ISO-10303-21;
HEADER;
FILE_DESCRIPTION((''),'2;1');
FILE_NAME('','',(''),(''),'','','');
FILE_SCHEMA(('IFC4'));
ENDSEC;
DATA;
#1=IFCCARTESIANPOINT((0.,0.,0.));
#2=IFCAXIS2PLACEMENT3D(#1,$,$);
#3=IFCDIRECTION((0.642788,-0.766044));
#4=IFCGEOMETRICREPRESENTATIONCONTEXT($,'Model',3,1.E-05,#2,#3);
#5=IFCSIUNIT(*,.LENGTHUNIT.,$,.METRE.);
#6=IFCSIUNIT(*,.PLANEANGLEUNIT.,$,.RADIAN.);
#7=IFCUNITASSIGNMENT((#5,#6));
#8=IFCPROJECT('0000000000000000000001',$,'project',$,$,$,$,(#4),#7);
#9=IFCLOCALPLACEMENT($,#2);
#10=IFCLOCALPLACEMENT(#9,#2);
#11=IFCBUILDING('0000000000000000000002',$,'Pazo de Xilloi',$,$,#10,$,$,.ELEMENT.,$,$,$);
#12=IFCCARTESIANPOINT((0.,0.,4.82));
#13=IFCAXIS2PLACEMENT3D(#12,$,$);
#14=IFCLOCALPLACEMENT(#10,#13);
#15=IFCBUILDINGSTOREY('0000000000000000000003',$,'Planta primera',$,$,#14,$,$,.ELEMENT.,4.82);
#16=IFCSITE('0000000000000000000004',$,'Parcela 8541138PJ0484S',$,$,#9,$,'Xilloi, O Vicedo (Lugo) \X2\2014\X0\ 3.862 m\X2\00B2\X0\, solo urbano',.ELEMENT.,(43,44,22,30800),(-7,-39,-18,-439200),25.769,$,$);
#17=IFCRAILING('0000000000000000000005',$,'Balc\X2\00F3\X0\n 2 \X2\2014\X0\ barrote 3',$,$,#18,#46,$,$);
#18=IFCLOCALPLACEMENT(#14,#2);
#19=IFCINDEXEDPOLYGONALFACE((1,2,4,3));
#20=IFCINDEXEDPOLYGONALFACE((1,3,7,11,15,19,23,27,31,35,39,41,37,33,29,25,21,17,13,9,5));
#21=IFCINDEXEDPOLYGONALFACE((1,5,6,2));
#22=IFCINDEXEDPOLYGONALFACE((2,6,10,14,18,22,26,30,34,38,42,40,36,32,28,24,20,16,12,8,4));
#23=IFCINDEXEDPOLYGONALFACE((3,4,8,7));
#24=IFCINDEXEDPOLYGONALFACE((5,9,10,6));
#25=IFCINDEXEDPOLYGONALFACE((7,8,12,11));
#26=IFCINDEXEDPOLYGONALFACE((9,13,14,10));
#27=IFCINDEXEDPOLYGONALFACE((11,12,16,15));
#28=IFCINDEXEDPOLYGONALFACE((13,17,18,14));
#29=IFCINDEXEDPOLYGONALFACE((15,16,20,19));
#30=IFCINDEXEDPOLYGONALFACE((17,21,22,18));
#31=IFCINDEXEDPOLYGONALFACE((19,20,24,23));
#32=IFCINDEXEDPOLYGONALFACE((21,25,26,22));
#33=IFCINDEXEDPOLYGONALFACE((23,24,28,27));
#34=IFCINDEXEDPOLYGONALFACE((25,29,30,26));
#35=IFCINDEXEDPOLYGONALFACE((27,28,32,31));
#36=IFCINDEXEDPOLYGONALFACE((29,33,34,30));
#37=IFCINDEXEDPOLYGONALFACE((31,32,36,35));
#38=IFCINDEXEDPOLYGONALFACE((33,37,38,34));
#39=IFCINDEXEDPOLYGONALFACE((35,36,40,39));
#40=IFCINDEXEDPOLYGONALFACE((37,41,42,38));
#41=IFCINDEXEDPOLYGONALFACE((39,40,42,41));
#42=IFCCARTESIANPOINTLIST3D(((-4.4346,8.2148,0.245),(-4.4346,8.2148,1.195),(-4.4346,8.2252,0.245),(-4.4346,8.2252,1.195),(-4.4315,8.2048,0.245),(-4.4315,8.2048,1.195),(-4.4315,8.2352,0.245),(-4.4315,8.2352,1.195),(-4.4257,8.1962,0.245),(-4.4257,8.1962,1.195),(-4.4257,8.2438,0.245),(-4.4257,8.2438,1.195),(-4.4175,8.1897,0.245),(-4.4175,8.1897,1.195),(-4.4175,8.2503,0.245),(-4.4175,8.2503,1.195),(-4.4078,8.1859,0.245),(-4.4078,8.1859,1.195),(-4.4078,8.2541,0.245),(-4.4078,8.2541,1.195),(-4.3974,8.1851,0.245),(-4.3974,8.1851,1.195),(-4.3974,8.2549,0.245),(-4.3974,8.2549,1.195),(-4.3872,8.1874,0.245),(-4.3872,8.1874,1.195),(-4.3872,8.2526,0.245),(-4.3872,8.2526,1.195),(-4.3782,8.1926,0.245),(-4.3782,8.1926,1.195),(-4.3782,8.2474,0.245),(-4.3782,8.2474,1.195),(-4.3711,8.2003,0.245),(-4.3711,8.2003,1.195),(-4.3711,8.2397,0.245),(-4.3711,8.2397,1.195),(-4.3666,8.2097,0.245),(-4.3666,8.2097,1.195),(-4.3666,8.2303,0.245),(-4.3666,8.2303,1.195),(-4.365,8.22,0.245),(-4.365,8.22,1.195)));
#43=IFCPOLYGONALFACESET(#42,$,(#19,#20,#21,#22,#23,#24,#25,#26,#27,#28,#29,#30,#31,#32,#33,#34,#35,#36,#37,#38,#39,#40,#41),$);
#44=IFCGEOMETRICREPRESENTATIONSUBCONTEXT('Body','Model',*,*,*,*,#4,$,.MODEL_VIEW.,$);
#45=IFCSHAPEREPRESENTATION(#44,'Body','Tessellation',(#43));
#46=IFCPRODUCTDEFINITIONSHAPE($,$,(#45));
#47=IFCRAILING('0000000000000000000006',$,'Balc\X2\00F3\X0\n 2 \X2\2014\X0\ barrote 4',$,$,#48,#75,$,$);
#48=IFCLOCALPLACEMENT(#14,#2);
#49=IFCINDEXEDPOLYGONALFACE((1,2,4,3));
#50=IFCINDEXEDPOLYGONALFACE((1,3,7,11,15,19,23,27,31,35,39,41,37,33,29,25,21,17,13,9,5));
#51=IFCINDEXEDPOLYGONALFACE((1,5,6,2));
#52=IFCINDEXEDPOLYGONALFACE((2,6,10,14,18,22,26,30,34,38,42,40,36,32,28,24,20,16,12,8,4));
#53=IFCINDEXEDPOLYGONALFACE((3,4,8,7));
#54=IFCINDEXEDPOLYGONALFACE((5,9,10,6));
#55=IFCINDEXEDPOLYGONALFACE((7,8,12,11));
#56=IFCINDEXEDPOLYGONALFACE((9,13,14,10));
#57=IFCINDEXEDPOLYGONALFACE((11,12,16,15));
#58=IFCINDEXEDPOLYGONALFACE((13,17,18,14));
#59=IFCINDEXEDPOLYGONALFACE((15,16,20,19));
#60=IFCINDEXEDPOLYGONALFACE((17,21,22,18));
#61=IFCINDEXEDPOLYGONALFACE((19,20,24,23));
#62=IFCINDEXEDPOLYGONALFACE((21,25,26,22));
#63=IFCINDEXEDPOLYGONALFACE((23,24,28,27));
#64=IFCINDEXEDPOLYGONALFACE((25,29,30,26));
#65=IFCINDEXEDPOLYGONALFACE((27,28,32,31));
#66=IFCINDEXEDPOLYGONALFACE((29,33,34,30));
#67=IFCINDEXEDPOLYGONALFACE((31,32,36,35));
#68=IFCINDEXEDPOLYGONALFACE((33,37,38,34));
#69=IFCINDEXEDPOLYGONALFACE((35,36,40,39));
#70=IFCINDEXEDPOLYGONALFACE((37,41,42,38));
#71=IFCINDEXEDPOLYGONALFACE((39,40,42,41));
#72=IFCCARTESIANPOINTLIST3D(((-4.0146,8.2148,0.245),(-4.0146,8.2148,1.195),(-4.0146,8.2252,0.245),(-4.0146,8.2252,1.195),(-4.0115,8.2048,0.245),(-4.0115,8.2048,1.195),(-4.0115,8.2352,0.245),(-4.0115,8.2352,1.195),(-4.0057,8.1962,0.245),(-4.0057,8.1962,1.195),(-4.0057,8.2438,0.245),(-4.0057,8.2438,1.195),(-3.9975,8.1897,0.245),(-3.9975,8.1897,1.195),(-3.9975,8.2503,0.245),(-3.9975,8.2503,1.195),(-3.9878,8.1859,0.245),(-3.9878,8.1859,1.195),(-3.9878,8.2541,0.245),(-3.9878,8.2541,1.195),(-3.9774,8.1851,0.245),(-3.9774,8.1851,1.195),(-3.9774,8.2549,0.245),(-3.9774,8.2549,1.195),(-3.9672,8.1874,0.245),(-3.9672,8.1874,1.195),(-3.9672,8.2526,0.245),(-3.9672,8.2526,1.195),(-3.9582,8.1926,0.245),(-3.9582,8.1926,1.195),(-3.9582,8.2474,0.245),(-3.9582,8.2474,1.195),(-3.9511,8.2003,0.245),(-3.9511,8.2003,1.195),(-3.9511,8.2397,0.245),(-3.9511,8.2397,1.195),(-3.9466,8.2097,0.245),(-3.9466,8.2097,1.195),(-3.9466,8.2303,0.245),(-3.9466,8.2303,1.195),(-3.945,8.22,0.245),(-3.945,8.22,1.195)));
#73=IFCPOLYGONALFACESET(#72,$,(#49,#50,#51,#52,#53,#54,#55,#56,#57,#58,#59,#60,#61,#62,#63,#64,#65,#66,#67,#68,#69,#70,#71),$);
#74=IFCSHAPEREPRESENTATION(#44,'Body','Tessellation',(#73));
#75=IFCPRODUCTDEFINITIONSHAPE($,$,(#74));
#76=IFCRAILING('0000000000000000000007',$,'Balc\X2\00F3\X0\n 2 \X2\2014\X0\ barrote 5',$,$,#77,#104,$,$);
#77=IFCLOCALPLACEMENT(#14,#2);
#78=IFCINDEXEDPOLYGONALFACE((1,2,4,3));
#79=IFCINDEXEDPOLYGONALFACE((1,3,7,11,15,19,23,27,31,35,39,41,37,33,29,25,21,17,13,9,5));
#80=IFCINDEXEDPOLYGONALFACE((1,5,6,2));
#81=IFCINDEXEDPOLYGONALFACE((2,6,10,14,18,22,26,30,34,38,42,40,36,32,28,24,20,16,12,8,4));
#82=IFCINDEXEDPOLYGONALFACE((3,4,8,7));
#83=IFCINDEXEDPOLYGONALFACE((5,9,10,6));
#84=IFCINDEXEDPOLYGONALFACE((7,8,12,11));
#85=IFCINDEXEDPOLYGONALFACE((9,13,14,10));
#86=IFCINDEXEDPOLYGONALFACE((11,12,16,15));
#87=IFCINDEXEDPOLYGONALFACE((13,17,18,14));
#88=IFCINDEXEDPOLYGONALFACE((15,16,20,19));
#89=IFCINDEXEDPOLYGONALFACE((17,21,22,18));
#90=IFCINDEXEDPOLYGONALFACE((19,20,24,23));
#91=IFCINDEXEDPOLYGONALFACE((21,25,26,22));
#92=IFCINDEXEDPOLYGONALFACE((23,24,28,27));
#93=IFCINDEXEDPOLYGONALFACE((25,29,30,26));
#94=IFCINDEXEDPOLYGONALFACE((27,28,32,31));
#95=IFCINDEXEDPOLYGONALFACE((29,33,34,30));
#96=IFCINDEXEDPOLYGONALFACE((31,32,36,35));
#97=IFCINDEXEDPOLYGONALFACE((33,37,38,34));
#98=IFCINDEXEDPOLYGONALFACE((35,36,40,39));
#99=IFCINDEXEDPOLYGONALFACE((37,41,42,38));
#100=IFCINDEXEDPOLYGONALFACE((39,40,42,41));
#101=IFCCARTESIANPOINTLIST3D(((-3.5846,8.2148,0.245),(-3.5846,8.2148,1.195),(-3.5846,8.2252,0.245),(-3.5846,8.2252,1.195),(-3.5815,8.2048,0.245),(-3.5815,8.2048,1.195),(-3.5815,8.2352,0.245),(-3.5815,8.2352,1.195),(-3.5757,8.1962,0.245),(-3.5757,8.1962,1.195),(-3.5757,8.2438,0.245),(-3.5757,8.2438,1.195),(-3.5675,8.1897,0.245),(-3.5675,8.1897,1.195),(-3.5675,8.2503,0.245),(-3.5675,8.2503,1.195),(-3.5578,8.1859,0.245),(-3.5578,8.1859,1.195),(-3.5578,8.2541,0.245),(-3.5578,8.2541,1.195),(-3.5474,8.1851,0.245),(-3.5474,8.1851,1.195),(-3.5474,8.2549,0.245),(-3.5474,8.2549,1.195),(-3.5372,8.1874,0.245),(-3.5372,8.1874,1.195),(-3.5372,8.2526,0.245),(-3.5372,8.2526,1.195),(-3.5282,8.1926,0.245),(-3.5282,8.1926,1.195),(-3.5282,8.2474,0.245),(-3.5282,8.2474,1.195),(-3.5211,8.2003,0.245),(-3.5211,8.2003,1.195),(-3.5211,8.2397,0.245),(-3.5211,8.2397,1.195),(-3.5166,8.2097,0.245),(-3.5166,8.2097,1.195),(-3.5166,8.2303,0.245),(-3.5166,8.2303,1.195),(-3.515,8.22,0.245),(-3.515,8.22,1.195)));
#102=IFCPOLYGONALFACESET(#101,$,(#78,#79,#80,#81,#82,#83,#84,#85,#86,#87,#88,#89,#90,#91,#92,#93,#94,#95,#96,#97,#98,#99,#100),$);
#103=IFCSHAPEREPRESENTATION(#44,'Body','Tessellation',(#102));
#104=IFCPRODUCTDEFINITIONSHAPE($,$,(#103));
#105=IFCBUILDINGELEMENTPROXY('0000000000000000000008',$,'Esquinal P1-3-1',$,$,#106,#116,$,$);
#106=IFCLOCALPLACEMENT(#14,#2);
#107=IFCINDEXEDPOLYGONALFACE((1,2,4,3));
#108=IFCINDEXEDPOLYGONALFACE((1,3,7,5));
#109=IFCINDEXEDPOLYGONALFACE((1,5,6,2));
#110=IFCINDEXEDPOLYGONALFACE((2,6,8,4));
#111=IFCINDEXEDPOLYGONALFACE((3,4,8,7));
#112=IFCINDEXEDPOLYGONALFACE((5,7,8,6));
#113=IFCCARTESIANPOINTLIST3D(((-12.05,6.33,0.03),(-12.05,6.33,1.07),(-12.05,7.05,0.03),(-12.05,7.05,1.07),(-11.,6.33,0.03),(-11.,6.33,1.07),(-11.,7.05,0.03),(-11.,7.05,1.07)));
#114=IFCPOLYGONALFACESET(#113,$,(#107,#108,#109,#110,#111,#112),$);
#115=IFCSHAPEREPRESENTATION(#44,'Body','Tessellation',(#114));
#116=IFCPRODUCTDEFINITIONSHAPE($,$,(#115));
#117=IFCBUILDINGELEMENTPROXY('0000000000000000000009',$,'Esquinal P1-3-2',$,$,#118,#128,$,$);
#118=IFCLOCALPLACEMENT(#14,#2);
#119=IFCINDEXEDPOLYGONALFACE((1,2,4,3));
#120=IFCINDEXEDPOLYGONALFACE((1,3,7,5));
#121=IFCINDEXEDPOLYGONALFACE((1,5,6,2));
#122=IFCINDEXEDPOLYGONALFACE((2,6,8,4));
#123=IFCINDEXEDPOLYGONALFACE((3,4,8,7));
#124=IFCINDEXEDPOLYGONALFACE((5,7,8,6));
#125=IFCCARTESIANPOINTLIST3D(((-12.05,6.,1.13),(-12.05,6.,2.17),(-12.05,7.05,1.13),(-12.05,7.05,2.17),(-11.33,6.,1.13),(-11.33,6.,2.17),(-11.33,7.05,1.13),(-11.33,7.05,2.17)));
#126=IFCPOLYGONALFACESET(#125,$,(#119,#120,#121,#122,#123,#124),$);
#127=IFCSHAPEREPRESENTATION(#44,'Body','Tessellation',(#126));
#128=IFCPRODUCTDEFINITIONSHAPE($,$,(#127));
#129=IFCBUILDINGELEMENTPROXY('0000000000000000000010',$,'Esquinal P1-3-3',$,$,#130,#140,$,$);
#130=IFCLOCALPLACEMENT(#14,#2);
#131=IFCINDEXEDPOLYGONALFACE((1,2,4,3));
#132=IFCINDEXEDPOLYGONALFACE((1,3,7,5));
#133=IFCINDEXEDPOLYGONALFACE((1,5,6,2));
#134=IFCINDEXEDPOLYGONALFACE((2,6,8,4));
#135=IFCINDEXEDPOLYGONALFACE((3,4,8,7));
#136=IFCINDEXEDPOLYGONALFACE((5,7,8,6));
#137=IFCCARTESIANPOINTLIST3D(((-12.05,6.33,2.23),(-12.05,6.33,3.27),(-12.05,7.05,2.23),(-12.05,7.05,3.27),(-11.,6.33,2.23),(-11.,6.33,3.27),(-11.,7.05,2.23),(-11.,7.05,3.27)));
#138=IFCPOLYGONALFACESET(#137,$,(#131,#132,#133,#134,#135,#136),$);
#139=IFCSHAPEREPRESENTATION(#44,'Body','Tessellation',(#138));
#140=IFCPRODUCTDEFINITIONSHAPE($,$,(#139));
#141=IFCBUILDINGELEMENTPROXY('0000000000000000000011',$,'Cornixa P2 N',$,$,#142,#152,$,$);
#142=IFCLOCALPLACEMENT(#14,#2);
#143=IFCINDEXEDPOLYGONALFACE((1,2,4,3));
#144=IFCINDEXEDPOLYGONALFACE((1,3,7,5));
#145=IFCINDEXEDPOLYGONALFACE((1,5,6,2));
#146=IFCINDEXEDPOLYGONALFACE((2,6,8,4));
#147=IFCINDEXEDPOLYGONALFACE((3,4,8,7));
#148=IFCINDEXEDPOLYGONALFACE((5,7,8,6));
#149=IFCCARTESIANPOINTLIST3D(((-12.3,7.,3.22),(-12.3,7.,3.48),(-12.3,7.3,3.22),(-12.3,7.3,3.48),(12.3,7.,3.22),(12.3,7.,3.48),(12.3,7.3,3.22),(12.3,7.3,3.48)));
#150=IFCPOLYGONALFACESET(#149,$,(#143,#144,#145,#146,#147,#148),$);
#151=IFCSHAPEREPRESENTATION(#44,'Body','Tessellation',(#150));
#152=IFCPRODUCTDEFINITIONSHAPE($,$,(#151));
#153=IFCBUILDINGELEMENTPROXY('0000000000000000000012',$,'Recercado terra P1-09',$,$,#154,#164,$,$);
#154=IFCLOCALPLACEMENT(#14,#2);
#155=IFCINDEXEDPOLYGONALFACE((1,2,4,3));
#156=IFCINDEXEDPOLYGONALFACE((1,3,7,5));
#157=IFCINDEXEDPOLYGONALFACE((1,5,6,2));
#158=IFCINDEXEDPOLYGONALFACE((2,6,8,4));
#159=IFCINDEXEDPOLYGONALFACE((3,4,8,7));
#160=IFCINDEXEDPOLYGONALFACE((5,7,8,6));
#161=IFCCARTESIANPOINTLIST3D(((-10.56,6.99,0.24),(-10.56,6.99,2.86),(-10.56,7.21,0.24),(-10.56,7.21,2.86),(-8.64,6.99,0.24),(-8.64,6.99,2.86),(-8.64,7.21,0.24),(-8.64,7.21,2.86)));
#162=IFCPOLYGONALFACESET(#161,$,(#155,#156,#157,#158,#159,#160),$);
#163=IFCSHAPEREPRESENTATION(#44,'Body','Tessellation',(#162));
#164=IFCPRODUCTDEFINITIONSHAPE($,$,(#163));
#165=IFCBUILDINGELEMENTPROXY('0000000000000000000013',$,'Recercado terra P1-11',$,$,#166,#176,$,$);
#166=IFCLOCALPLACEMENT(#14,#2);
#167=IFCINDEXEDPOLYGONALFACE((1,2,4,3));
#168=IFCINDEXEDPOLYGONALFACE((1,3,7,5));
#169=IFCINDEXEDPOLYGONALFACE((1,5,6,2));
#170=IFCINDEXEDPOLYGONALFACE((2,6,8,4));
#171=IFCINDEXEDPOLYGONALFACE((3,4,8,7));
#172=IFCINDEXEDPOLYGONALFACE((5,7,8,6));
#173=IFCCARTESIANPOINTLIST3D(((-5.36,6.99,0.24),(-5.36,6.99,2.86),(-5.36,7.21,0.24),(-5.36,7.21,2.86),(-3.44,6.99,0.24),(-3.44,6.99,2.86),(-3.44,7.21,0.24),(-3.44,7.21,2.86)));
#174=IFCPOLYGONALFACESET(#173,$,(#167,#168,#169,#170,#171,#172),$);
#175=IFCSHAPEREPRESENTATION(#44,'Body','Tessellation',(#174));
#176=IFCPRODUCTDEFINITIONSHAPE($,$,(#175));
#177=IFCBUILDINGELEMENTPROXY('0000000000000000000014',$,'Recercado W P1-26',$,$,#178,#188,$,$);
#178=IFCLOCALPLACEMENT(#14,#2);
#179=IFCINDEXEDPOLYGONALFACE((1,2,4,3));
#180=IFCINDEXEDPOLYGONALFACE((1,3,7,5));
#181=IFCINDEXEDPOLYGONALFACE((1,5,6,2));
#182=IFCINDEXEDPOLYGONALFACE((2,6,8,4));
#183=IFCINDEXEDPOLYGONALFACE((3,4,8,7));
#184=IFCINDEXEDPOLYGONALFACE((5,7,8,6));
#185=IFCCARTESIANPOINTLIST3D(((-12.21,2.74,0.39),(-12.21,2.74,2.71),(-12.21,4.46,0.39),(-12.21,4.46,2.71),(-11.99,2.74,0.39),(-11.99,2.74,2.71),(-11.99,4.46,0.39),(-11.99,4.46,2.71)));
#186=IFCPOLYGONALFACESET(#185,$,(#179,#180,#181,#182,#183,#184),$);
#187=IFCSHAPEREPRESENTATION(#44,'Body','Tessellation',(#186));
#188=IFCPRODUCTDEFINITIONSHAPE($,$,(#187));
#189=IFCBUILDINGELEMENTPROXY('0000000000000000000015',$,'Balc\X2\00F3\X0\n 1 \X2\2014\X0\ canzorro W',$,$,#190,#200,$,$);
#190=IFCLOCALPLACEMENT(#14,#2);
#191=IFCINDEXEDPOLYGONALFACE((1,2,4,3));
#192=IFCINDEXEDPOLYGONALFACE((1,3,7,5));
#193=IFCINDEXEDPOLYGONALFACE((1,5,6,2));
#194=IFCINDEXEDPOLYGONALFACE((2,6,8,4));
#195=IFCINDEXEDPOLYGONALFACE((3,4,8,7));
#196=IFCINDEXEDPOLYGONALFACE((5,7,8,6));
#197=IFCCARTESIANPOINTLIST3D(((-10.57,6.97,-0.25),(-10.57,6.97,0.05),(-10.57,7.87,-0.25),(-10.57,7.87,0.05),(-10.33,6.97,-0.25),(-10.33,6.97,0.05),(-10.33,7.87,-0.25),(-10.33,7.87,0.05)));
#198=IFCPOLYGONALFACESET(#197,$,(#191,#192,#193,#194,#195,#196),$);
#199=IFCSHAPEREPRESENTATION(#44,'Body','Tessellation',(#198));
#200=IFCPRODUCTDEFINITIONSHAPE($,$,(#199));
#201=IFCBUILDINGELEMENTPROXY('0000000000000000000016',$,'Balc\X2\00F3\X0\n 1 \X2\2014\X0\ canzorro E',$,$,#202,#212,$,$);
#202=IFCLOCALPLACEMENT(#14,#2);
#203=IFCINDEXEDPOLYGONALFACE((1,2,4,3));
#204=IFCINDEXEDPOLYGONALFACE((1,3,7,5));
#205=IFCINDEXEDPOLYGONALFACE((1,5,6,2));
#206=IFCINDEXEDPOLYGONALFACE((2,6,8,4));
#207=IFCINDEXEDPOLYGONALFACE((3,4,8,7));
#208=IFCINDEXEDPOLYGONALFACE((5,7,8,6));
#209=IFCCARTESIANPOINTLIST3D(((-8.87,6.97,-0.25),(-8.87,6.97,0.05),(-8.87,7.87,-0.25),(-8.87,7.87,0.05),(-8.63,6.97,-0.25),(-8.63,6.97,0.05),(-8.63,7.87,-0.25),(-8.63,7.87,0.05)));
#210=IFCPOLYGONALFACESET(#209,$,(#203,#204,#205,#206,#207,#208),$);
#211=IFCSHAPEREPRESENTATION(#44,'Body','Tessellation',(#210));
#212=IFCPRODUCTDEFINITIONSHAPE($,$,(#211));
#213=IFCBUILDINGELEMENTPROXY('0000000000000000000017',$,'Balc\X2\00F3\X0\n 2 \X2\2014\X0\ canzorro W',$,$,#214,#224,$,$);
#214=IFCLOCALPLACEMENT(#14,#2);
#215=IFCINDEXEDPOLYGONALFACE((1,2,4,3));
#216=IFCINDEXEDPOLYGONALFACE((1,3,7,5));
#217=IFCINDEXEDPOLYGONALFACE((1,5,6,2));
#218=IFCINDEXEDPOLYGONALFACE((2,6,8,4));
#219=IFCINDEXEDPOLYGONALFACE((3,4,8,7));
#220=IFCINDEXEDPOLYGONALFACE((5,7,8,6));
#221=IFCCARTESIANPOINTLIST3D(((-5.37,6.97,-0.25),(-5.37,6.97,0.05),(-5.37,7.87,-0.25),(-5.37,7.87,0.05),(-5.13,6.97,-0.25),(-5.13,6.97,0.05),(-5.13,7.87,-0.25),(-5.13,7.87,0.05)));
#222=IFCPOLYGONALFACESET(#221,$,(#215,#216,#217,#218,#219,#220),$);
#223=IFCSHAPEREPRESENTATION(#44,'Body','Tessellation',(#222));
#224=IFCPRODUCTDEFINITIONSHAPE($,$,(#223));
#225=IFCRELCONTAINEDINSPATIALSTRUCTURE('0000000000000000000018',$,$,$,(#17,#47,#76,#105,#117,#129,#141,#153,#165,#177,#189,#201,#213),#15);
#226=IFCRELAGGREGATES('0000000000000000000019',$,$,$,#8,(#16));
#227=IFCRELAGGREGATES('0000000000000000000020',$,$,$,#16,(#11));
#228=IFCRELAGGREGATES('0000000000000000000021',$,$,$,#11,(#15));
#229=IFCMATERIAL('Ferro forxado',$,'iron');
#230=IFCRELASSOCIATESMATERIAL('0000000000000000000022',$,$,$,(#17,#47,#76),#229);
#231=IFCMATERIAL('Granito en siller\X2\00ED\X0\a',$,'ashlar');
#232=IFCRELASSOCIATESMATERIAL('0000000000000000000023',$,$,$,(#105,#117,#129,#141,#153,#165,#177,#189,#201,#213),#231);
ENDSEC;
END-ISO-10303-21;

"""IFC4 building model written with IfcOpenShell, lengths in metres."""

from ifc_helpers import new_model, si_unit, direction, frame, origin, origin_2d, place, context, subcontext, project, spatial, rectangle, circle, extrude, material, element, save


model = new_model("IFC4")

# Units and contexts
model_context = context("Model", 3, precision=1e-05, world=origin(), true_north=direction((0.642788, -0.766044)))
body_context = subcontext(model_context, "Body", "Model", "MODEL_VIEW")
ifc_project = project(units=[si_unit("LENGTHUNIT", "METRE"), si_unit("PLANEANGLEUNIT", "RADIAN")], contexts=[model_context])

# Site, building, storey
site_placement = place(None, origin())
site = spatial("IfcSite", under=ifc_project, at=site_placement, Name="Parcela 8541138PJ0484S", LongName="Xilloi, O Vicedo (Lugo) — 3.862 m², solo urbano", CompositionType="ELEMENT", RefLatitude=(43, 44, 22, 30800), RefLongitude=(-7, -39, -18, -439200), RefElevation=25.769)
building_placement = place(site_placement, origin())
building = spatial("IfcBuilding", under=site, at=building_placement, Name="Pazo de Xilloi", CompositionType="ELEMENT")
storey_placement = place(building_placement, frame((0.0, 0.0, 4.82)))
storey = spatial("IfcBuildingStorey", under=building, at=storey_placement, Name="Planta primera", CompositionType="ELEMENT", Elevation=4.82)

# Shared definitions
ifc_material_1 = material(Name="Granito en sillería", Category="ashlar")

# Railings
ifc_material_2 = material(Name="Ferro forxado", Category="iron")
for number, where, name in (
    (1, (-4.4, 8.22, 0.72), "Balcón 2 — barrote 3"),
    (2, (-3.98, 8.22, 0.72), "Balcón 2 — barrote 4"),
    (3, (-3.55, 8.22, 0.72), "Balcón 2 — barrote 5"),
):
    element("IfcRailing", number, at=place(storey_placement, frame(where)), inside=storey, material=ifc_material_2, Name=name, context=body_context, shape_type="SweptSolid", body=[
        extrude(circle(Radius=0.035, at=origin_2d()), frame((0.0, 0.0, -0.475)), (0.0, 0.0, 1.0), 0.95),
    ])

# Building element proxies
proxy_1_placement = place(storey_placement, frame((-11.525, 6.69, 0.55)))
element("IfcBuildingElementProxy", 4, at=proxy_1_placement, inside=storey, material=ifc_material_1, Name="Esquinal P1-3-1", context=body_context, shape_type="SweptSolid", body=[
    extrude(rectangle(XDim=1.05, YDim=0.72, at=origin_2d()), frame((0.0, 0.0, -0.52)), (0.0, 0.0, 1.0), 1.04),
])
proxy_2_placement = place(storey_placement, frame((-11.69, 6.525, 1.65)))
element("IfcBuildingElementProxy", 5, at=proxy_2_placement, inside=storey, material=ifc_material_1, Name="Esquinal P1-3-2", context=body_context, shape_type="SweptSolid", body=[
    extrude(rectangle(XDim=0.72, YDim=1.05, at=origin_2d()), frame((0.0, 0.0, -0.52)), (0.0, 0.0, 1.0), 1.04),
])
proxy_3_placement = place(storey_placement, frame((-11.525, 6.69, 2.75)))
element("IfcBuildingElementProxy", 6, at=proxy_3_placement, inside=storey, material=ifc_material_1, Name="Esquinal P1-3-3", context=body_context, shape_type="SweptSolid", body=[
    extrude(rectangle(XDim=1.05, YDim=0.72, at=origin_2d()), frame((0.0, 0.0, -0.52)), (0.0, 0.0, 1.0), 1.04),
])
proxy_4_placement = place(storey_placement, frame((0.0, 7.15, 3.35)))
element("IfcBuildingElementProxy", 7, at=proxy_4_placement, inside=storey, material=ifc_material_1, Name="Cornixa P2 N", context=body_context, shape_type="SweptSolid", body=[
    extrude(rectangle(XDim=24.6, YDim=0.3, at=origin_2d()), frame((0.0, 0.0, -0.13)), (0.0, 0.0, 1.0), 0.26),
])
for number, where, name in (
    (8, (-9.6, 7.1, 1.55), "Recercado terra P1-09"),
    (9, (-4.4, 7.1, 1.55), "Recercado terra P1-11"),
):
    element("IfcBuildingElementProxy", number, at=place(storey_placement, frame(where)), inside=storey, material=ifc_material_1, Name=name, context=body_context, shape_type="SweptSolid", body=[
        extrude(rectangle(XDim=1.92, YDim=0.22, at=origin_2d()), frame((0.0, 0.0, -1.31)), (0.0, 0.0, 1.0), 2.62),
    ])
proxy_5_placement = place(storey_placement, frame((-12.1, 3.6, 1.55)))
element("IfcBuildingElementProxy", 10, at=proxy_5_placement, inside=storey, material=ifc_material_1, Name="Recercado W P1-26", context=body_context, shape_type="SweptSolid", body=[
    extrude(rectangle(XDim=0.22, YDim=1.72, at=origin_2d()), frame((0.0, 0.0, -1.16)), (0.0, 0.0, 1.0), 2.32),
])
for number, where, name in (
    (11, (-10.45, 7.42, -0.1), "Balcón 1 — canzorro W"),
    (12, (-8.75, 7.42, -0.1), "Balcón 1 — canzorro E"),
    (13, (-5.25, 7.42, -0.1), "Balcón 2 — canzorro W"),
):
    element("IfcBuildingElementProxy", number, at=place(storey_placement, frame(where)), inside=storey, material=ifc_material_1, Name=name, context=body_context, shape_type="SweptSolid", body=[
        extrude(rectangle(XDim=0.24, YDim=0.9, at=origin_2d()), frame((0.0, 0.0, -0.15)), (0.0, 0.0, 1.0), 0.3),
    ])

save(model, "model.ifc")
